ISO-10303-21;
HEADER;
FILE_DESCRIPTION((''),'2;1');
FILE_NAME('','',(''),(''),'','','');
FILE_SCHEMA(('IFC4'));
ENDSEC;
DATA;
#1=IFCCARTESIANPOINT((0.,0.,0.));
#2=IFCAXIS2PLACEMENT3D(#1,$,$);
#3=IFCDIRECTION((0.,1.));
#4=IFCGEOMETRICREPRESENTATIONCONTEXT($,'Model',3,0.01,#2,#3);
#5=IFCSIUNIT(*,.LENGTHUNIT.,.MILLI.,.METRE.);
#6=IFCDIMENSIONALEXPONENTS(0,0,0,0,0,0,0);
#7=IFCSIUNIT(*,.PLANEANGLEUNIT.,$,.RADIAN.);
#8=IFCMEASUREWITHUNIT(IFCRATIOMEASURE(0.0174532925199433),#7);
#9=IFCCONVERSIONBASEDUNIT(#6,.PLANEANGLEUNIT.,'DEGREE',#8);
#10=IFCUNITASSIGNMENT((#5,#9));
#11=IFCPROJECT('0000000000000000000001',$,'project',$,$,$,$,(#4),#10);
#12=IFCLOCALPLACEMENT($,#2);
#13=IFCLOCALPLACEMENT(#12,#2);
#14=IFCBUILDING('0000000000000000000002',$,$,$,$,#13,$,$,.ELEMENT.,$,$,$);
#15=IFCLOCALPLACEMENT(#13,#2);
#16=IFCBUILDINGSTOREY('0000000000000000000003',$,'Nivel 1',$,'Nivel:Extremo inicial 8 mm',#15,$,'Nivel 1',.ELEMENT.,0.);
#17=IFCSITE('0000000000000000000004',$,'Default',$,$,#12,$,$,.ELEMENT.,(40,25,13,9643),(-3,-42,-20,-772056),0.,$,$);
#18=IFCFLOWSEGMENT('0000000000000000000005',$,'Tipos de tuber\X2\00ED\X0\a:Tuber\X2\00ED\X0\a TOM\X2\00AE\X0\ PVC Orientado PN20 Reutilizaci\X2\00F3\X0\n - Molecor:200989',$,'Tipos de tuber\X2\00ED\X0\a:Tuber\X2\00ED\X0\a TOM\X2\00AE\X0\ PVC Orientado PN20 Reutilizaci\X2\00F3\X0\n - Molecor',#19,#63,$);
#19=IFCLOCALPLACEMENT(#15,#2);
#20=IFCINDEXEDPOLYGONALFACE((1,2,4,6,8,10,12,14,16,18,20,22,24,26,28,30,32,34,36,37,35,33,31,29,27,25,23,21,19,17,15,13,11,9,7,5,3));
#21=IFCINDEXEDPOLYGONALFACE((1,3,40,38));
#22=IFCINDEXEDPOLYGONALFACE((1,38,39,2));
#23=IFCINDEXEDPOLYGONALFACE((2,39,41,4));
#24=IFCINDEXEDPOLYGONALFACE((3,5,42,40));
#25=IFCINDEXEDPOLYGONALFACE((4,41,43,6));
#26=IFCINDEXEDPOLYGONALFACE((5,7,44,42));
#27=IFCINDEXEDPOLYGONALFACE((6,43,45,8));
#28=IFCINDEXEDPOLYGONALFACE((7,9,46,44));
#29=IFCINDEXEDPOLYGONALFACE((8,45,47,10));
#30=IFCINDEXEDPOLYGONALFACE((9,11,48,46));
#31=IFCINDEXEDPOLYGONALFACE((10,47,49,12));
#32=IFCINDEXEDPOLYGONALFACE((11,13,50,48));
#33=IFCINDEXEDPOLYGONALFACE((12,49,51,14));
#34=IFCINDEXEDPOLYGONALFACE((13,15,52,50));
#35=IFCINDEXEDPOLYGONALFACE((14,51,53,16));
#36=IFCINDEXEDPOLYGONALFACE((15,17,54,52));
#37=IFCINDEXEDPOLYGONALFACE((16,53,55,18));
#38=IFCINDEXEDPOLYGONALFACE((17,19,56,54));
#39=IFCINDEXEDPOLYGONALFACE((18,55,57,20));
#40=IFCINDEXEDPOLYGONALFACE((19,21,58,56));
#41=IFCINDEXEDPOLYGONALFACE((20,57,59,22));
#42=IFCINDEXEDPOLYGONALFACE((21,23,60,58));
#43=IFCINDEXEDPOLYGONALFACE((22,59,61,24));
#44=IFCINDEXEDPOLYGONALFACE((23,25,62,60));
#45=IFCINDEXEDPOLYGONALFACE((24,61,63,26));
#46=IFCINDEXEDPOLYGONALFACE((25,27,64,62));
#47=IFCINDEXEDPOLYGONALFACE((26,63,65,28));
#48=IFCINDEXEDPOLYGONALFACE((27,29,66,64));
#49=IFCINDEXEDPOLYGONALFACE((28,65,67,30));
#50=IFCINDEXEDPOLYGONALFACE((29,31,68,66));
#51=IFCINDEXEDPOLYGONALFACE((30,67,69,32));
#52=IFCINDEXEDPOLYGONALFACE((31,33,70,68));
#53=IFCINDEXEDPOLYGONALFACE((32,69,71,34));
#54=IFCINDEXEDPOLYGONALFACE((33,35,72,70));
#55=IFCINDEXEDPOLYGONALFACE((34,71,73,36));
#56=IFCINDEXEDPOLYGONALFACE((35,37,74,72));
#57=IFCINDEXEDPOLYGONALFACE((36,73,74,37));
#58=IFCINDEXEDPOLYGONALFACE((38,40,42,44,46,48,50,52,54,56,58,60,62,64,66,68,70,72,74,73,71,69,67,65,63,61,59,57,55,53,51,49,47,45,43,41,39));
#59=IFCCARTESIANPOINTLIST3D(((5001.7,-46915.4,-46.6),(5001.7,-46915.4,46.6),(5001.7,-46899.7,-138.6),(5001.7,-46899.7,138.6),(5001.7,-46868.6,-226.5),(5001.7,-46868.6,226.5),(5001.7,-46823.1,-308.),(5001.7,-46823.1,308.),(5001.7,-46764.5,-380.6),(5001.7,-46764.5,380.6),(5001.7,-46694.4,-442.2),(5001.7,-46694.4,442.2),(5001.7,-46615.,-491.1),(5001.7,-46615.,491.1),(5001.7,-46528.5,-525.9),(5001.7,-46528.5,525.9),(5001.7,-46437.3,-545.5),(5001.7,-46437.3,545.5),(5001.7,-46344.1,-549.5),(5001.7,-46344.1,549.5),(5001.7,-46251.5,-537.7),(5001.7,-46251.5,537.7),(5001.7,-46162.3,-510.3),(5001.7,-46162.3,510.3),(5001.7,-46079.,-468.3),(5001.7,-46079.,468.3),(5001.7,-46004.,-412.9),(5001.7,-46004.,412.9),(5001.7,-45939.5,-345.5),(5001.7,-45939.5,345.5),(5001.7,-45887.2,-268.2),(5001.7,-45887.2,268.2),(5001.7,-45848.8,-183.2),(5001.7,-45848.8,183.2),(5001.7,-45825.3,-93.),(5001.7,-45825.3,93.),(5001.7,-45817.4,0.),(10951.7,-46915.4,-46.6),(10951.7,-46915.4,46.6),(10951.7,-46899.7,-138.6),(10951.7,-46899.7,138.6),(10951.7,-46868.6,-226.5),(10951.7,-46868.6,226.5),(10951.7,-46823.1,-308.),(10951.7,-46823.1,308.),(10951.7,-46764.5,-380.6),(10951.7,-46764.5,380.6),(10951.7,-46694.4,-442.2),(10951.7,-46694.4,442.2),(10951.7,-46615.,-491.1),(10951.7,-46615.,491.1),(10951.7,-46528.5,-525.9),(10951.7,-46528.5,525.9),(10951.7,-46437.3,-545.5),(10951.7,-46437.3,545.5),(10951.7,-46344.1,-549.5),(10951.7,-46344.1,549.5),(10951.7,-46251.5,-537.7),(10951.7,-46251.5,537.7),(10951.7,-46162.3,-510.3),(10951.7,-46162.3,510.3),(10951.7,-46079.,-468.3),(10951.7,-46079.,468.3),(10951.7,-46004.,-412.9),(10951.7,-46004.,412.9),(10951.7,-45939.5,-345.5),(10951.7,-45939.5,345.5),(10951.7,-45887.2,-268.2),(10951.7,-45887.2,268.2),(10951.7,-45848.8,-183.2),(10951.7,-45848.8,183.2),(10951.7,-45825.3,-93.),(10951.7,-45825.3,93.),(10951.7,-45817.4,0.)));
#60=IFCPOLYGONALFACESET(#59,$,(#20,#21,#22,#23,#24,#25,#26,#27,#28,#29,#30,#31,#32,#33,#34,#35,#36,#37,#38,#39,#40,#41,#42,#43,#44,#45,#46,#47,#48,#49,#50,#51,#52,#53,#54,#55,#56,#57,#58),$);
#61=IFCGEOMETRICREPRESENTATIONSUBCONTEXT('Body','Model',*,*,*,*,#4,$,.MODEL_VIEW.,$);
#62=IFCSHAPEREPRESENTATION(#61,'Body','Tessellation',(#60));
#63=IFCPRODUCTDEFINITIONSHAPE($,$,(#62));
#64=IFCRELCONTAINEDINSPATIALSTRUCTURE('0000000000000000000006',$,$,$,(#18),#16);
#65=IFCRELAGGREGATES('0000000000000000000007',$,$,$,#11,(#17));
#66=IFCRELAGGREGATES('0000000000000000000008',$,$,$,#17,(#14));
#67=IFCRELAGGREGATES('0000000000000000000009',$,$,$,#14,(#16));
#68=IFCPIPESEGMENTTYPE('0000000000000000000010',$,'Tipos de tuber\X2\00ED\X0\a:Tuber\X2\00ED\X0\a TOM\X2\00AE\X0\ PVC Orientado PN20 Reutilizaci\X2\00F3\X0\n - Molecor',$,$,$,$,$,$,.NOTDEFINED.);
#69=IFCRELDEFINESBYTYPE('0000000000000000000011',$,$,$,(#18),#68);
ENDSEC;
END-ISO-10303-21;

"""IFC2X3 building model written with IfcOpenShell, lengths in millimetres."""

from ifc_helpers import new_model, entity, si_unit, converted_unit, direction, frame, frame_2d, origin, place, context, subcontext, project, spatial, circle, extrude, type_object, element, save


model = new_model("IFC2X3")

# Units and contexts
model_context = context("Model", 3, precision=0.01, world=origin(), true_north=direction((0.0, 1.0)))
body_context = subcontext(model_context, "Body", "Model", "MODEL_VIEW")
ifc_project = project(units=[si_unit("LENGTHUNIT", "METRE", prefix="MILLI"), converted_unit("PLANEANGLEUNIT", "DEGREE", entity("IfcRatioMeasure", 0.0174532925199433), si_unit("PLANEANGLEUNIT", "RADIAN"), dimensions=[0, 0, 0, 0, 0, 0, 0])], contexts=[model_context])

# Site, building, storey
site_placement = place(None, origin())
site = spatial("IfcSite", under=ifc_project, at=site_placement, Name="Default", CompositionType="ELEMENT", RefLatitude=(40, 25, 13, 9643), RefLongitude=(-3, -42, -20, -772056), RefElevation=0.0)
building_placement = place(site_placement, origin())
building = spatial("IfcBuilding", under=site, at=building_placement, CompositionType="ELEMENT")
storey_placement = place(building_placement, origin())
storey = spatial("IfcBuildingStorey", under=building, at=storey_placement, Name="Nivel 1", ObjectType="Nivel:Extremo inicial 8 mm", LongName="Nivel 1", CompositionType="ELEMENT", Elevation=0.0)

# Flow segment
pipe_segment_type_1 = type_object("IfcPipeSegmentType", Name="Tipos de tubería:Tubería TOM® PVC Orientado PN20 Reutilización - Molecor", PredefinedType="NOTDEFINED")
flow_segment_1_placement = place(storey_placement, frame((5001.7, -46919.0, -551.6)))
element("IfcFlowSegment", 1, at=flow_segment_1_placement, inside=storey, type_object=pipe_segment_type_1, Name="Tipos de tubería:Tubería TOM® PVC Orientado PN20 Reutilización - Molecor:200989", ObjectType="Tipos de tubería:Tubería TOM® PVC Orientado PN20 Reutilización - Molecor", context=body_context, shape_type="SweptSolid", body=[
    extrude(circle(Radius=550.0, at=frame_2d((0.0, 0.0), x_axis=(1.0, 0.0))), frame((0.0, 551.6, 551.6), z_axis=(1.0, 0.0, 0.0), x_axis=(0.0, 1.0, 0.0)), (0.0, 0.0, 1.0), 5950.0),
])

save(model, "model.ifc")
